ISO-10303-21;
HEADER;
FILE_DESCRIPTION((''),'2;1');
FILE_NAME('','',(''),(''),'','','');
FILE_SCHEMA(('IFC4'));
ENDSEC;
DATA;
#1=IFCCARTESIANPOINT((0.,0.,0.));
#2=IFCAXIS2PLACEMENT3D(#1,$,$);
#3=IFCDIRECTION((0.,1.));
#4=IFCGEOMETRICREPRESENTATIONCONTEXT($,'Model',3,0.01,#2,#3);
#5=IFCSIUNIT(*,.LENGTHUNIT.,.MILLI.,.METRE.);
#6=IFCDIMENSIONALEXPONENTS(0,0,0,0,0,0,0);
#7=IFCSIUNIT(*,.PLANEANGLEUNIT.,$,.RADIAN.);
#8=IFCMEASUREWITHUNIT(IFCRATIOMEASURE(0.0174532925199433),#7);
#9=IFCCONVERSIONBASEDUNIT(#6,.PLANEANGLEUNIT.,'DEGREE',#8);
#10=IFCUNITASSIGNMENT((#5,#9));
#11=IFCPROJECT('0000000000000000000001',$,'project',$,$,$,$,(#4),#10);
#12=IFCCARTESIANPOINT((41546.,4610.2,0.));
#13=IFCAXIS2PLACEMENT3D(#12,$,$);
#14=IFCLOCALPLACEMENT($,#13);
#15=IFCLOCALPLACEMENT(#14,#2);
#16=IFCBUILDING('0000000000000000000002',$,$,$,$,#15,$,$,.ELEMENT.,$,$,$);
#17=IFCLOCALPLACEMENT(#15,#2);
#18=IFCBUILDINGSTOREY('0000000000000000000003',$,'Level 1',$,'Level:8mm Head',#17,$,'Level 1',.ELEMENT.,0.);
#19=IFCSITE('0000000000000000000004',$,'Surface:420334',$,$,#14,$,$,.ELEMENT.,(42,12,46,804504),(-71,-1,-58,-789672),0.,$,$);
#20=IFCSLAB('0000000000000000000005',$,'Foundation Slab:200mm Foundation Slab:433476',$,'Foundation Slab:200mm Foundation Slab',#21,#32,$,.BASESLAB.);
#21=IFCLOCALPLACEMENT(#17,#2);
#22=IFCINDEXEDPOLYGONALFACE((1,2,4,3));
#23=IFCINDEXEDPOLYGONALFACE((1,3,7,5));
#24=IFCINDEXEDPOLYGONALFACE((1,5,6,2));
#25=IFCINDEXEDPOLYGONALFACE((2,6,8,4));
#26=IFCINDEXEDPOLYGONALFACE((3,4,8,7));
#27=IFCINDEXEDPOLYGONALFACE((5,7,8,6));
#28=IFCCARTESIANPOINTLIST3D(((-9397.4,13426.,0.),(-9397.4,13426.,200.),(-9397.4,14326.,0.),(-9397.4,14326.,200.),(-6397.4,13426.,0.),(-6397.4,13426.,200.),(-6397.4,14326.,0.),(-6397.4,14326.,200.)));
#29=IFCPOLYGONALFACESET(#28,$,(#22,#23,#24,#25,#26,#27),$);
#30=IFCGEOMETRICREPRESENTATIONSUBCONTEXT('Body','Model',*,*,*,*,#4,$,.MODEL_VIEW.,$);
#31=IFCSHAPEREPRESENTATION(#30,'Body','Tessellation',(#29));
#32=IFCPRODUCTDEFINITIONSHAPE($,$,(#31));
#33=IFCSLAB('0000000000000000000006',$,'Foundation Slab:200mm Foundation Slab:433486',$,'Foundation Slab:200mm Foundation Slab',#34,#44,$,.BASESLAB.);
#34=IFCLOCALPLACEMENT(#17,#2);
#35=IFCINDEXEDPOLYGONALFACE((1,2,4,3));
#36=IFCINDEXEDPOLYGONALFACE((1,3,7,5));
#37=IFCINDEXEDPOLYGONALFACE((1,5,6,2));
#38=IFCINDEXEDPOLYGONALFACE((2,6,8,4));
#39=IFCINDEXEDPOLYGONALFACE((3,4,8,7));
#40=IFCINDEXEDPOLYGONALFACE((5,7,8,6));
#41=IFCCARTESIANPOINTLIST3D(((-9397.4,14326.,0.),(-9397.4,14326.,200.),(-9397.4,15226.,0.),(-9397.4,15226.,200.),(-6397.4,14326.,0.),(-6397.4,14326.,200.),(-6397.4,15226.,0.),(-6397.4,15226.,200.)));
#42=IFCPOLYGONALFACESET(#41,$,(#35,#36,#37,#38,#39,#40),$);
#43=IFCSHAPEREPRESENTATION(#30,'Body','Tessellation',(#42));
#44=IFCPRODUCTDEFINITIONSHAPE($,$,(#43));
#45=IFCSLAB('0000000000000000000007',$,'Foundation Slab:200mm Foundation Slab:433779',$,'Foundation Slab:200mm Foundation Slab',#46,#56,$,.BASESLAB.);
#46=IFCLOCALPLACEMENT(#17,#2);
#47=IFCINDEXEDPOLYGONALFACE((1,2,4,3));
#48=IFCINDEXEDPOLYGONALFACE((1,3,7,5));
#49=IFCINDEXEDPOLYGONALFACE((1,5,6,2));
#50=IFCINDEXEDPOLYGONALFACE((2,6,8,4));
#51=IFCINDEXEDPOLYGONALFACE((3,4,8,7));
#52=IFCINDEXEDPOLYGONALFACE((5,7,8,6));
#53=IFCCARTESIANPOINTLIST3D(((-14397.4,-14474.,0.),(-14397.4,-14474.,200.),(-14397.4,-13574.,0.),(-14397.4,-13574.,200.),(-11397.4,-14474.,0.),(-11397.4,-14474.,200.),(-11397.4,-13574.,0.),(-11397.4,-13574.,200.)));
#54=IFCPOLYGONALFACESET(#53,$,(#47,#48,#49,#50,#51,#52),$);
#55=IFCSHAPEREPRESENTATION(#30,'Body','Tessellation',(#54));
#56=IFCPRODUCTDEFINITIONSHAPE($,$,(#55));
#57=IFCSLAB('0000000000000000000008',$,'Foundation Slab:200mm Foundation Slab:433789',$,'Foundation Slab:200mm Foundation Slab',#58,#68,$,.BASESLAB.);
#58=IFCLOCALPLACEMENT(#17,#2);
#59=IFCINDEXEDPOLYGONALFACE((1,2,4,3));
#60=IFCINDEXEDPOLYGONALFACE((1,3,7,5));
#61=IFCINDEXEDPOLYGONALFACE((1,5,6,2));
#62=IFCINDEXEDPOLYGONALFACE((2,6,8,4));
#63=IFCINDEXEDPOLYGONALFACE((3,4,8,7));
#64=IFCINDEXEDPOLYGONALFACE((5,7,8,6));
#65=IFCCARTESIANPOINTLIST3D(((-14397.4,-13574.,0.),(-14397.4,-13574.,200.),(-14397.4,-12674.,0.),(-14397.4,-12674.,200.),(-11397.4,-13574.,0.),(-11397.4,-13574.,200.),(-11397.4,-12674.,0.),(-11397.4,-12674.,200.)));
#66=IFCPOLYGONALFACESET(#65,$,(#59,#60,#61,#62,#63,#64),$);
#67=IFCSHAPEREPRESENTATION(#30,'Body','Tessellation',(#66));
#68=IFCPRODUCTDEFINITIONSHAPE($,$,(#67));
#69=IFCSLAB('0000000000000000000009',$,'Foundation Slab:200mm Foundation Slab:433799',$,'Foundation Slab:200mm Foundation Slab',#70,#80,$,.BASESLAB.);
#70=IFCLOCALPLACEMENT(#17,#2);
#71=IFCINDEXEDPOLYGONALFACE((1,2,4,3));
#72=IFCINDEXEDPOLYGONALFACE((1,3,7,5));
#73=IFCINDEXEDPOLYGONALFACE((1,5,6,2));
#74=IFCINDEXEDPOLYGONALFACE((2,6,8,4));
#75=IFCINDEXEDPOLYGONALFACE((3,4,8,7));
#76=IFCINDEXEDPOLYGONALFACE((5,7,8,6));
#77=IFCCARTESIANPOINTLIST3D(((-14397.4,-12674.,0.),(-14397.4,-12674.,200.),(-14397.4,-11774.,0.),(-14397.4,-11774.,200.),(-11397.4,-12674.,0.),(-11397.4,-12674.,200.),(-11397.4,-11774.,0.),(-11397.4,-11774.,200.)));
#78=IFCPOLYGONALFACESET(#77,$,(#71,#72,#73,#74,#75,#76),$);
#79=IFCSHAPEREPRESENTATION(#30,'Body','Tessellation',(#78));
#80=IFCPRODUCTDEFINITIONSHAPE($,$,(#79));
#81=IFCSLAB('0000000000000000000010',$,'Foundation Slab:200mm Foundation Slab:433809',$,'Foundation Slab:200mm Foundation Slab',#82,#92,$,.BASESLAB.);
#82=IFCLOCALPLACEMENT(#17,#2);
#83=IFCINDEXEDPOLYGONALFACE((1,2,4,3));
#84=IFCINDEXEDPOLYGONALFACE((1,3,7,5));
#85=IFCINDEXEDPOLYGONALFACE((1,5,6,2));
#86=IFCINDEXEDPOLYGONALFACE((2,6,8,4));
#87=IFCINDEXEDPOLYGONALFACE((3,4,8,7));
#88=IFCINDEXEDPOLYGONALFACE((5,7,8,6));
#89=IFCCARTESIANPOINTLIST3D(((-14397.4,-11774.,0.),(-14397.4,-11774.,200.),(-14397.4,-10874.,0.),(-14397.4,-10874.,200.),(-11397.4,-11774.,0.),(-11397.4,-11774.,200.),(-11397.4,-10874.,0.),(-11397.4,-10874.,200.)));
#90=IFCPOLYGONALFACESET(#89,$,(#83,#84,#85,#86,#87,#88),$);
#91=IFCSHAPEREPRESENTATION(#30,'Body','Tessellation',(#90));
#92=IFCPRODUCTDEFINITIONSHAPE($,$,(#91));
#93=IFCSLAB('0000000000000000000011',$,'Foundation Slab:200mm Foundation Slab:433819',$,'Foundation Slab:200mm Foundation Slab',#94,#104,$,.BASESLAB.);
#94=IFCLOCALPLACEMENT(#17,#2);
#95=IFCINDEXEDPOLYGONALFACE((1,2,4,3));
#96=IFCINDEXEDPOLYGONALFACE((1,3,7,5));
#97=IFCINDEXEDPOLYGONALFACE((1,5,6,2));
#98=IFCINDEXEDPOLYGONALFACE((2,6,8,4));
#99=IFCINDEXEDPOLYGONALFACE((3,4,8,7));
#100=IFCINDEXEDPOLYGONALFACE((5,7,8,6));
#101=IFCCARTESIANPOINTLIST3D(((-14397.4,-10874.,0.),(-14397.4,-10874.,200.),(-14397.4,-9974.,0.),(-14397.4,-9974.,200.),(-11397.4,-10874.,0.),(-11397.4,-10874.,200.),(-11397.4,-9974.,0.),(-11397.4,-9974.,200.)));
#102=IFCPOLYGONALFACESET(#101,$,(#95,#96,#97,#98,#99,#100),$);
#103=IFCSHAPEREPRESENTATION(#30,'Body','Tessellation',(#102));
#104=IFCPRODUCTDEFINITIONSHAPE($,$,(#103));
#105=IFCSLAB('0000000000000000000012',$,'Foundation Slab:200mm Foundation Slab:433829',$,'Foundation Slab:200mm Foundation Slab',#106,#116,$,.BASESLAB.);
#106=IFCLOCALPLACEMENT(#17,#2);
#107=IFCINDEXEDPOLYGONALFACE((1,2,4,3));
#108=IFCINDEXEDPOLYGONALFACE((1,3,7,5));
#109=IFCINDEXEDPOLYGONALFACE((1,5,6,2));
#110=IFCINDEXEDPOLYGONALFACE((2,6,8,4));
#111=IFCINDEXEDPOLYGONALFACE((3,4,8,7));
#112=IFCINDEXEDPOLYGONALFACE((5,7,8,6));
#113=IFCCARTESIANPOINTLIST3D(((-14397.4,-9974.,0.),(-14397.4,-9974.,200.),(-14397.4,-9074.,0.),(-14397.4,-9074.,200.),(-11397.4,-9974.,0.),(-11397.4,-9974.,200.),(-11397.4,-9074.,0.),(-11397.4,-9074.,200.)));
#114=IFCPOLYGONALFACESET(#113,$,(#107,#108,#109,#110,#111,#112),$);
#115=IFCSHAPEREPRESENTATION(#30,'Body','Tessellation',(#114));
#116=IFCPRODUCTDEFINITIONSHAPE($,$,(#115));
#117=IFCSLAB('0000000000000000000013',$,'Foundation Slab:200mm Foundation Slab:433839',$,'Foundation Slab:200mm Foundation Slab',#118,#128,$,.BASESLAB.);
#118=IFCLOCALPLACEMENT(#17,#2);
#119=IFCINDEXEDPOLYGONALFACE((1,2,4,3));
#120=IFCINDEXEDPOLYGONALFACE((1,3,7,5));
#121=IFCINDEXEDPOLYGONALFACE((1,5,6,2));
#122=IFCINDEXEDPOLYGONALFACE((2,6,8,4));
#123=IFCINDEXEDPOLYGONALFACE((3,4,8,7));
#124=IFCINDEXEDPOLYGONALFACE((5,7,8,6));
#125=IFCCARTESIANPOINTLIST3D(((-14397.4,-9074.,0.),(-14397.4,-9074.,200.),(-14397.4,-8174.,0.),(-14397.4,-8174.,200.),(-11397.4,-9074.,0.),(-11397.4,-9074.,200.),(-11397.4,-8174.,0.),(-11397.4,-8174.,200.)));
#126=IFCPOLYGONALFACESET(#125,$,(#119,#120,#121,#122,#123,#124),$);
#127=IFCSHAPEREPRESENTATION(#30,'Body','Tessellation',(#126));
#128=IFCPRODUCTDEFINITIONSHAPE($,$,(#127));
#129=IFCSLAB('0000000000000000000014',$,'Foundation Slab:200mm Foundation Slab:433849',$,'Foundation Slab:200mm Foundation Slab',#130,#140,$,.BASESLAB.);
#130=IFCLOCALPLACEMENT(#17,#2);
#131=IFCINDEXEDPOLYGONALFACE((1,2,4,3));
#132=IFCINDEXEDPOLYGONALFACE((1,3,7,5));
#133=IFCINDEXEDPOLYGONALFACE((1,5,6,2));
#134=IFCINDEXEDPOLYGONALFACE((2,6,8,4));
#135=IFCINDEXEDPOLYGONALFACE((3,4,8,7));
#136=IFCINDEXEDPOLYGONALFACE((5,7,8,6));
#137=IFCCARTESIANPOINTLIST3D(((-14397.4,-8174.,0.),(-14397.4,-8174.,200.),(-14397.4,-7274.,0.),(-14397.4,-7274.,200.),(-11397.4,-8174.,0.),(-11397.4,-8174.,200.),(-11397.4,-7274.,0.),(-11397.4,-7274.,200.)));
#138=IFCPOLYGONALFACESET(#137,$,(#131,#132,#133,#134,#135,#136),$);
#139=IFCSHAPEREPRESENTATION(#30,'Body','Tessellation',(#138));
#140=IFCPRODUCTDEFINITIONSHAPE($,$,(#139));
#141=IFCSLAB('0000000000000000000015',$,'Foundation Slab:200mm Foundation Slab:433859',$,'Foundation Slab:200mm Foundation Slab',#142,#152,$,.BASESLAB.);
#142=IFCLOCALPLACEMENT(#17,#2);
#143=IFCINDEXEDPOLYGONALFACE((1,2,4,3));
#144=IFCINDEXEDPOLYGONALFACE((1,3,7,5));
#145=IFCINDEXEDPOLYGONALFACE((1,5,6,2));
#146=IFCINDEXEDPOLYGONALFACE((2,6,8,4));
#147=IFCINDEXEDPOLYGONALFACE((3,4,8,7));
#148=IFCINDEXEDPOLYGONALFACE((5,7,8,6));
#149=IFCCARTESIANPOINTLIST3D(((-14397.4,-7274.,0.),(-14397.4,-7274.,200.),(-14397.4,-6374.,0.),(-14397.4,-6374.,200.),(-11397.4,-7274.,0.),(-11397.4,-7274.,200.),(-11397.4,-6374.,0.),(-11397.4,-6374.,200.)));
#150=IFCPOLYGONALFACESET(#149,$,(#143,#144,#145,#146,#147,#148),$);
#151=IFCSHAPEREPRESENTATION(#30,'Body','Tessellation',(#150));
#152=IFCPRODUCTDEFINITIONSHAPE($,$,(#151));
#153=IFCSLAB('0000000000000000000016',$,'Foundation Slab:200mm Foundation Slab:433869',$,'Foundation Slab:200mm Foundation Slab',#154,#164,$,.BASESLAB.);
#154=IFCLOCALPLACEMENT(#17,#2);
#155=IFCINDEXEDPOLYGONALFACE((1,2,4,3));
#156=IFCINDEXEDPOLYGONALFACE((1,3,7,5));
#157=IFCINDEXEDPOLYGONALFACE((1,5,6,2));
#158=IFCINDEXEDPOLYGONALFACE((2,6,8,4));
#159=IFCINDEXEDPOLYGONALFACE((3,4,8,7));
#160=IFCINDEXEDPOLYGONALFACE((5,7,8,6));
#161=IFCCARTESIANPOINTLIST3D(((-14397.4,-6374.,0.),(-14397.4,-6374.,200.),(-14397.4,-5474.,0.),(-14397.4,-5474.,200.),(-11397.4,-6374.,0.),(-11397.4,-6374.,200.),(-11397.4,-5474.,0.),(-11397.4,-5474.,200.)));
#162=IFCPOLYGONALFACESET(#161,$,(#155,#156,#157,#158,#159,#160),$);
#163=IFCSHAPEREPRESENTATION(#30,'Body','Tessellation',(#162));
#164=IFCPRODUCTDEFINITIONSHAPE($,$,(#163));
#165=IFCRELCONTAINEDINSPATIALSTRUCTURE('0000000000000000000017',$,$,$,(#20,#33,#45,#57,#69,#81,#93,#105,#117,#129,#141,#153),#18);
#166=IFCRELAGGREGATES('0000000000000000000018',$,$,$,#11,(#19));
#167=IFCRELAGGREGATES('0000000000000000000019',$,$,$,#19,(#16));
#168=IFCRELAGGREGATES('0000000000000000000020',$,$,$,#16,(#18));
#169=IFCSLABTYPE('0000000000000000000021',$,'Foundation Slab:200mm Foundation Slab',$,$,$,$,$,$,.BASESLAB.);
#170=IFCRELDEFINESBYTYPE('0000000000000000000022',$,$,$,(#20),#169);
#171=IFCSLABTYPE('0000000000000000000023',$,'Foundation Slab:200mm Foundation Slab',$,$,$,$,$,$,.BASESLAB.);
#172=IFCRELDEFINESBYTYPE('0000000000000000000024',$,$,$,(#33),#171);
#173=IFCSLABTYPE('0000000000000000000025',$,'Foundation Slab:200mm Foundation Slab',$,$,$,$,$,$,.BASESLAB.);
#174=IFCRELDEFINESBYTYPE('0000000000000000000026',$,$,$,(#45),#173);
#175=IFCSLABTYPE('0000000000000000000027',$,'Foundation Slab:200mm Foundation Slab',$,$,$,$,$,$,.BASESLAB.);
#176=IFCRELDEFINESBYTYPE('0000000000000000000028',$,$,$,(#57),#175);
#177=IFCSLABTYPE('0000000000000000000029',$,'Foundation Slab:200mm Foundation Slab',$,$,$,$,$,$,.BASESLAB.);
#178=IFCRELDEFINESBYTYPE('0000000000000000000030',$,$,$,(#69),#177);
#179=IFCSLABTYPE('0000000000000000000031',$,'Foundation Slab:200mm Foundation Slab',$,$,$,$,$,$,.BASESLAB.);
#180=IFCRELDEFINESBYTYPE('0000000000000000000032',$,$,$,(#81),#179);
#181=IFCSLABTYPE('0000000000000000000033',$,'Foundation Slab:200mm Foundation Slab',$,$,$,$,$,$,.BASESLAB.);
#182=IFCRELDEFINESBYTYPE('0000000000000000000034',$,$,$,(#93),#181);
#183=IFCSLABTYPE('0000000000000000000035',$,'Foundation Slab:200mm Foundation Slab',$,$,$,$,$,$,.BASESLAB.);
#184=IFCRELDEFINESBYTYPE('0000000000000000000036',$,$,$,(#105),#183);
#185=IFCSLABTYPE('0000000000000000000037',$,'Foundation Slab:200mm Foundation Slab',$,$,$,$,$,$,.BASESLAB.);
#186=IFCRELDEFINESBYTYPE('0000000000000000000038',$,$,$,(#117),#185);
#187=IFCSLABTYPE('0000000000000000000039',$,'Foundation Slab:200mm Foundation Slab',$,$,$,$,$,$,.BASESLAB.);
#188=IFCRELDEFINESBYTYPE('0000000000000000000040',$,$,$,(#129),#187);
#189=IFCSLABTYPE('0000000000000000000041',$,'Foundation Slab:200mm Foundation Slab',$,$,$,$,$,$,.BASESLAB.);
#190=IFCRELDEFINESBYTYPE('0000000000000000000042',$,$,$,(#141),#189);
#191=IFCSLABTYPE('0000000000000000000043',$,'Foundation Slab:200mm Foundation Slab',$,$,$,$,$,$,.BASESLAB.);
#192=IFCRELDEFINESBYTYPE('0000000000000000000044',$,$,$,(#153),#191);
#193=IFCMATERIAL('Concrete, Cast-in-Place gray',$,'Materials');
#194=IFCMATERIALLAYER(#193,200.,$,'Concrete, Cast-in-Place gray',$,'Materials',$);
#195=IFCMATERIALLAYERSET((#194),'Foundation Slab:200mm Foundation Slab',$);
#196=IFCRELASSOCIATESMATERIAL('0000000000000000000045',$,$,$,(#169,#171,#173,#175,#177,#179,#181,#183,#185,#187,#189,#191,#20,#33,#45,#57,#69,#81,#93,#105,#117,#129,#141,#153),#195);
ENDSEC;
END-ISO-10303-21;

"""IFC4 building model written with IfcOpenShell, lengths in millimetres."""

from ifc_helpers import new_model, entity, si_unit, converted_unit, direction, frame, frame_2d, origin, origin_2d_with_axis, place, context, subcontext, project, spatial, rectangle, extrude, material, layer, layer_set, layer_usage, type_object, element, save


model = new_model("IFC4")

# Units and contexts
model_context = context("Model", 3, precision=0.01, world=origin(), true_north=direction((0.0, 1.0)))
body_context = subcontext(model_context, "Body", "Model", "MODEL_VIEW")
ifc_project = project(units=[si_unit("LENGTHUNIT", "METRE", prefix="MILLI"), converted_unit("PLANEANGLEUNIT", "DEGREE", entity("IfcRatioMeasure", 0.0174532925199433), si_unit("PLANEANGLEUNIT", "RADIAN"), dimensions=[0, 0, 0, 0, 0, 0, 0])], contexts=[model_context])

# Site, building, storey
site_placement = place(None, frame((41546.0, 4610.2, 0.0)))
site = spatial("IfcSite", under=ifc_project, at=site_placement, Name="Surface:420334", CompositionType="ELEMENT", RefLatitude=(42, 12, 46, 804504), RefLongitude=(-71, -1, -58, -789672), RefElevation=0.0)
building_placement = place(site_placement, origin())
building = spatial("IfcBuilding", under=site, at=building_placement, CompositionType="ELEMENT")
storey_placement = place(building_placement, origin())
storey = spatial("IfcBuildingStorey", under=building, at=storey_placement, Name="Level 1", ObjectType="Level:8mm Head", LongName="Level 1", CompositionType="ELEMENT", Elevation=0.0)

# Slabs
ifc_material = material(Name="Concrete, Cast-in-Place gray", Category="Materials")
ifc_layer = layer(ifc_material, 200.0, Name="Concrete, Cast-in-Place gray", Category="Materials")
ifc_layer_set = layer_set([ifc_layer], Name="Foundation Slab:200mm Foundation Slab")
ifc_layer_usage_1 = layer_usage(ifc_layer_set, "AXIS3", "POSITIVE", 0.0)
slab_type_1 = type_object("IfcSlabType", Name="Foundation Slab:200mm Foundation Slab", PredefinedType="BASESLAB", material=ifc_layer_set)
slab_1_placement = place(storey_placement, origin())
element("IfcSlab", 1, at=slab_1_placement, inside=storey, type_object=slab_type_1, material=ifc_layer_usage_1, Name="Foundation Slab:200mm Foundation Slab:433476", ObjectType="Foundation Slab:200mm Foundation Slab", PredefinedType="BASESLAB", context=body_context, shape_type="SweptSolid", body=[
    extrude(rectangle(XDim=900.0, YDim=3000.0, at=frame_2d((0.0, 0.0), x_axis=(1.0, 0.0))), frame((-7897.4, 13876.0, 200.0), z_axis=(0.0, 0.0, -1.0), x_axis=(0.0, 1.0, 0.0)), (0.0, 0.0, 1.0), 200.0),
])
ifc_layer_usage_2 = layer_usage(ifc_layer_set, "AXIS3", "POSITIVE", 0.0)
slab_type_2 = type_object("IfcSlabType", Name="Foundation Slab:200mm Foundation Slab", PredefinedType="BASESLAB", material=ifc_layer_set)
slab_2_placement = place(storey_placement, origin())
element("IfcSlab", 2, at=slab_2_placement, inside=storey, type_object=slab_type_2, material=ifc_layer_usage_2, Name="Foundation Slab:200mm Foundation Slab:433486", ObjectType="Foundation Slab:200mm Foundation Slab", PredefinedType="BASESLAB", context=body_context, shape_type="SweptSolid", body=[
    extrude(rectangle(XDim=900.0, YDim=3000.0, at=frame_2d((0.0, 0.0), x_axis=(1.0, 0.0))), frame((-7897.4, 14776.0, 200.0), z_axis=(0.0, 0.0, -1.0), x_axis=(0.0, 1.0, 0.0)), (0.0, 0.0, 1.0), 200.0),
])
ifc_layer_usage_3 = layer_usage(ifc_layer_set, "AXIS3", "POSITIVE", 0.0)
slab_type_3 = type_object("IfcSlabType", Name="Foundation Slab:200mm Foundation Slab", PredefinedType="BASESLAB", material=ifc_layer_set)
slab_3_placement = place(storey_placement, origin())
element("IfcSlab", 3, at=slab_3_placement, inside=storey, type_object=slab_type_3, material=ifc_layer_usage_3, Name="Foundation Slab:200mm Foundation Slab:433779", ObjectType="Foundation Slab:200mm Foundation Slab", PredefinedType="BASESLAB", context=body_context, shape_type="SweptSolid", body=[
    extrude(rectangle(XDim=900.0, YDim=3000.0, at=origin_2d_with_axis()), frame((-12897.4, -14024.0, 200.0), z_axis=(0.0, 0.0, -1.0), x_axis=(0.0, 1.0, 0.0)), (0.0, 0.0, 1.0), 200.0),
])
ifc_layer_usage_4 = layer_usage(ifc_layer_set, "AXIS3", "POSITIVE", 0.0)
slab_type_4 = type_object("IfcSlabType", Name="Foundation Slab:200mm Foundation Slab", PredefinedType="BASESLAB", material=ifc_layer_set)
slab_4_placement = place(storey_placement, origin())
element("IfcSlab", 4, at=slab_4_placement, inside=storey, type_object=slab_type_4, material=ifc_layer_usage_4, Name="Foundation Slab:200mm Foundation Slab:433789", ObjectType="Foundation Slab:200mm Foundation Slab", PredefinedType="BASESLAB", context=body_context, shape_type="SweptSolid", body=[
    extrude(rectangle(XDim=900.0, YDim=3000.0, at=frame_2d((0.0, 0.0), x_axis=(1.0, 0.0))), frame((-12897.4, -13124.0, 200.0), z_axis=(0.0, 0.0, -1.0), x_axis=(0.0, 1.0, 0.0)), (0.0, 0.0, 1.0), 200.0),
])
ifc_layer_usage_5 = layer_usage(ifc_layer_set, "AXIS3", "POSITIVE", 0.0)
slab_type_5 = type_object("IfcSlabType", Name="Foundation Slab:200mm Foundation Slab", PredefinedType="BASESLAB", material=ifc_layer_set)
slab_5_placement = place(storey_placement, origin())
element("IfcSlab", 5, at=slab_5_placement, inside=storey, type_object=slab_type_5, material=ifc_layer_usage_5, Name="Foundation Slab:200mm Foundation Slab:433799", ObjectType="Foundation Slab:200mm Foundation Slab", PredefinedType="BASESLAB", context=body_context, shape_type="SweptSolid", body=[
    extrude(rectangle(XDim=900.0, YDim=3000.0, at=origin_2d_with_axis()), frame((-12897.4, -12224.0, 200.0), z_axis=(0.0, 0.0, -1.0), x_axis=(0.0, 1.0, 0.0)), (0.0, 0.0, 1.0), 200.0),
])
ifc_layer_usage_6 = layer_usage(ifc_layer_set, "AXIS3", "POSITIVE", 0.0)
slab_type_6 = type_object("IfcSlabType", Name="Foundation Slab:200mm Foundation Slab", PredefinedType="BASESLAB", material=ifc_layer_set)
slab_6_placement = place(storey_placement, origin())
element("IfcSlab", 6, at=slab_6_placement, inside=storey, type_object=slab_type_6, material=ifc_layer_usage_6, Name="Foundation Slab:200mm Foundation Slab:433809", ObjectType="Foundation Slab:200mm Foundation Slab", PredefinedType="BASESLAB", context=body_context, shape_type="SweptSolid", body=[
    extrude(rectangle(XDim=900.0, YDim=3000.0, at=origin_2d_with_axis()), frame((-12897.4, -11324.0, 200.0), z_axis=(0.0, 0.0, -1.0), x_axis=(0.0, 1.0, 0.0)), (0.0, 0.0, 1.0), 200.0),
])
ifc_layer_usage_7 = layer_usage(ifc_layer_set, "AXIS3", "POSITIVE", 0.0)
slab_type_7 = type_object("IfcSlabType", Name="Foundation Slab:200mm Foundation Slab", PredefinedType="BASESLAB", material=ifc_layer_set)
slab_7_placement = place(storey_placement, origin())
element("IfcSlab", 7, at=slab_7_placement, inside=storey, type_object=slab_type_7, material=ifc_layer_usage_7, Name="Foundation Slab:200mm Foundation Slab:433819", ObjectType="Foundation Slab:200mm Foundation Slab", PredefinedType="BASESLAB", context=body_context, shape_type="SweptSolid", body=[
    extrude(rectangle(XDim=900.0, YDim=3000.0, at=origin_2d_with_axis()), frame((-12897.4, -10424.0, 200.0), z_axis=(0.0, 0.0, -1.0), x_axis=(0.0, 1.0, 0.0)), (0.0, 0.0, 1.0), 200.0),
])
ifc_layer_usage_8 = layer_usage(ifc_layer_set, "AXIS3", "POSITIVE", 0.0)
slab_type_8 = type_object("IfcSlabType", Name="Foundation Slab:200mm Foundation Slab", PredefinedType="BASESLAB", material=ifc_layer_set)
slab_8_placement = place(storey_placement, origin())
element("IfcSlab", 8, at=slab_8_placement, inside=storey, type_object=slab_type_8, material=ifc_layer_usage_8, Name="Foundation Slab:200mm Foundation Slab:433829", ObjectType="Foundation Slab:200mm Foundation Slab", PredefinedType="BASESLAB", context=body_context, shape_type="SweptSolid", body=[
    extrude(rectangle(XDim=900.0, YDim=3000.0, at=origin_2d_with_axis()), frame((-12897.4, -9524.0, 200.0), z_axis=(0.0, 0.0, -1.0), x_axis=(0.0, 1.0, 0.0)), (0.0, 0.0, 1.0), 200.0),
])
ifc_layer_usage_9 = layer_usage(ifc_layer_set, "AXIS3", "POSITIVE", 0.0)
slab_type_9 = type_object("IfcSlabType", Name="Foundation Slab:200mm Foundation Slab", PredefinedType="BASESLAB", material=ifc_layer_set)
slab_9_placement = place(storey_placement, origin())
element("IfcSlab", 9, at=slab_9_placement, inside=storey, type_object=slab_type_9, material=ifc_layer_usage_9, Name="Foundation Slab:200mm Foundation Slab:433839", ObjectType="Foundation Slab:200mm Foundation Slab", PredefinedType="BASESLAB", context=body_context, shape_type="SweptSolid", body=[
    extrude(rectangle(XDim=900.0, YDim=3000.0, at=origin_2d_with_axis()), frame((-12897.4, -8624.0, 200.0), z_axis=(0.0, 0.0, -1.0), x_axis=(0.0, 1.0, 0.0)), (0.0, 0.0, 1.0), 200.0),
])
ifc_layer_usage_10 = layer_usage(ifc_layer_set, "AXIS3", "POSITIVE", 0.0)
slab_type_10 = type_object("IfcSlabType", Name="Foundation Slab:200mm Foundation Slab", PredefinedType="BASESLAB", material=ifc_layer_set)
slab_10_placement = place(storey_placement, origin())
element("IfcSlab", 10, at=slab_10_placement, inside=storey, type_object=slab_type_10, material=ifc_layer_usage_10, Name="Foundation Slab:200mm Foundation Slab:433849", ObjectType="Foundation Slab:200mm Foundation Slab", PredefinedType="BASESLAB", context=body_context, shape_type="SweptSolid", body=[
    extrude(rectangle(XDim=900.0, YDim=3000.0, at=origin_2d_with_axis()), frame((-12897.4, -7724.0, 200.0), z_axis=(0.0, 0.0, -1.0), x_axis=(0.0, 1.0, 0.0)), (0.0, 0.0, 1.0), 200.0),
])
ifc_layer_usage_11 = layer_usage(ifc_layer_set, "AXIS3", "POSITIVE", 0.0)
slab_type_11 = type_object("IfcSlabType", Name="Foundation Slab:200mm Foundation Slab", PredefinedType="BASESLAB", material=ifc_layer_set)
slab_11_placement = place(storey_placement, origin())
element("IfcSlab", 11, at=slab_11_placement, inside=storey, type_object=slab_type_11, material=ifc_layer_usage_11, Name="Foundation Slab:200mm Foundation Slab:433859", ObjectType="Foundation Slab:200mm Foundation Slab", PredefinedType="BASESLAB", context=body_context, shape_type="SweptSolid", body=[
    extrude(rectangle(XDim=900.0, YDim=3000.0, at=origin_2d_with_axis()), frame((-12897.4, -6824.0, 200.0), z_axis=(0.0, 0.0, -1.0), x_axis=(0.0, 1.0, 0.0)), (0.0, 0.0, 1.0), 200.0),
])
ifc_layer_usage_12 = layer_usage(ifc_layer_set, "AXIS3", "POSITIVE", 0.0)
slab_type_12 = type_object("IfcSlabType", Name="Foundation Slab:200mm Foundation Slab", PredefinedType="BASESLAB", material=ifc_layer_set)
slab_12_placement = place(storey_placement, origin())
element("IfcSlab", 12, at=slab_12_placement, inside=storey, type_object=slab_type_12, material=ifc_layer_usage_12, Name="Foundation Slab:200mm Foundation Slab:433869", ObjectType="Foundation Slab:200mm Foundation Slab", PredefinedType="BASESLAB", context=body_context, shape_type="SweptSolid", body=[
    extrude(rectangle(XDim=900.0, YDim=3000.0, at=origin_2d_with_axis()), frame((-12897.4, -5924.0, 200.0), z_axis=(0.0, 0.0, -1.0), x_axis=(0.0, 1.0, 0.0)), (0.0, 0.0, 1.0), 200.0),
])

save(model, "model.ifc")
